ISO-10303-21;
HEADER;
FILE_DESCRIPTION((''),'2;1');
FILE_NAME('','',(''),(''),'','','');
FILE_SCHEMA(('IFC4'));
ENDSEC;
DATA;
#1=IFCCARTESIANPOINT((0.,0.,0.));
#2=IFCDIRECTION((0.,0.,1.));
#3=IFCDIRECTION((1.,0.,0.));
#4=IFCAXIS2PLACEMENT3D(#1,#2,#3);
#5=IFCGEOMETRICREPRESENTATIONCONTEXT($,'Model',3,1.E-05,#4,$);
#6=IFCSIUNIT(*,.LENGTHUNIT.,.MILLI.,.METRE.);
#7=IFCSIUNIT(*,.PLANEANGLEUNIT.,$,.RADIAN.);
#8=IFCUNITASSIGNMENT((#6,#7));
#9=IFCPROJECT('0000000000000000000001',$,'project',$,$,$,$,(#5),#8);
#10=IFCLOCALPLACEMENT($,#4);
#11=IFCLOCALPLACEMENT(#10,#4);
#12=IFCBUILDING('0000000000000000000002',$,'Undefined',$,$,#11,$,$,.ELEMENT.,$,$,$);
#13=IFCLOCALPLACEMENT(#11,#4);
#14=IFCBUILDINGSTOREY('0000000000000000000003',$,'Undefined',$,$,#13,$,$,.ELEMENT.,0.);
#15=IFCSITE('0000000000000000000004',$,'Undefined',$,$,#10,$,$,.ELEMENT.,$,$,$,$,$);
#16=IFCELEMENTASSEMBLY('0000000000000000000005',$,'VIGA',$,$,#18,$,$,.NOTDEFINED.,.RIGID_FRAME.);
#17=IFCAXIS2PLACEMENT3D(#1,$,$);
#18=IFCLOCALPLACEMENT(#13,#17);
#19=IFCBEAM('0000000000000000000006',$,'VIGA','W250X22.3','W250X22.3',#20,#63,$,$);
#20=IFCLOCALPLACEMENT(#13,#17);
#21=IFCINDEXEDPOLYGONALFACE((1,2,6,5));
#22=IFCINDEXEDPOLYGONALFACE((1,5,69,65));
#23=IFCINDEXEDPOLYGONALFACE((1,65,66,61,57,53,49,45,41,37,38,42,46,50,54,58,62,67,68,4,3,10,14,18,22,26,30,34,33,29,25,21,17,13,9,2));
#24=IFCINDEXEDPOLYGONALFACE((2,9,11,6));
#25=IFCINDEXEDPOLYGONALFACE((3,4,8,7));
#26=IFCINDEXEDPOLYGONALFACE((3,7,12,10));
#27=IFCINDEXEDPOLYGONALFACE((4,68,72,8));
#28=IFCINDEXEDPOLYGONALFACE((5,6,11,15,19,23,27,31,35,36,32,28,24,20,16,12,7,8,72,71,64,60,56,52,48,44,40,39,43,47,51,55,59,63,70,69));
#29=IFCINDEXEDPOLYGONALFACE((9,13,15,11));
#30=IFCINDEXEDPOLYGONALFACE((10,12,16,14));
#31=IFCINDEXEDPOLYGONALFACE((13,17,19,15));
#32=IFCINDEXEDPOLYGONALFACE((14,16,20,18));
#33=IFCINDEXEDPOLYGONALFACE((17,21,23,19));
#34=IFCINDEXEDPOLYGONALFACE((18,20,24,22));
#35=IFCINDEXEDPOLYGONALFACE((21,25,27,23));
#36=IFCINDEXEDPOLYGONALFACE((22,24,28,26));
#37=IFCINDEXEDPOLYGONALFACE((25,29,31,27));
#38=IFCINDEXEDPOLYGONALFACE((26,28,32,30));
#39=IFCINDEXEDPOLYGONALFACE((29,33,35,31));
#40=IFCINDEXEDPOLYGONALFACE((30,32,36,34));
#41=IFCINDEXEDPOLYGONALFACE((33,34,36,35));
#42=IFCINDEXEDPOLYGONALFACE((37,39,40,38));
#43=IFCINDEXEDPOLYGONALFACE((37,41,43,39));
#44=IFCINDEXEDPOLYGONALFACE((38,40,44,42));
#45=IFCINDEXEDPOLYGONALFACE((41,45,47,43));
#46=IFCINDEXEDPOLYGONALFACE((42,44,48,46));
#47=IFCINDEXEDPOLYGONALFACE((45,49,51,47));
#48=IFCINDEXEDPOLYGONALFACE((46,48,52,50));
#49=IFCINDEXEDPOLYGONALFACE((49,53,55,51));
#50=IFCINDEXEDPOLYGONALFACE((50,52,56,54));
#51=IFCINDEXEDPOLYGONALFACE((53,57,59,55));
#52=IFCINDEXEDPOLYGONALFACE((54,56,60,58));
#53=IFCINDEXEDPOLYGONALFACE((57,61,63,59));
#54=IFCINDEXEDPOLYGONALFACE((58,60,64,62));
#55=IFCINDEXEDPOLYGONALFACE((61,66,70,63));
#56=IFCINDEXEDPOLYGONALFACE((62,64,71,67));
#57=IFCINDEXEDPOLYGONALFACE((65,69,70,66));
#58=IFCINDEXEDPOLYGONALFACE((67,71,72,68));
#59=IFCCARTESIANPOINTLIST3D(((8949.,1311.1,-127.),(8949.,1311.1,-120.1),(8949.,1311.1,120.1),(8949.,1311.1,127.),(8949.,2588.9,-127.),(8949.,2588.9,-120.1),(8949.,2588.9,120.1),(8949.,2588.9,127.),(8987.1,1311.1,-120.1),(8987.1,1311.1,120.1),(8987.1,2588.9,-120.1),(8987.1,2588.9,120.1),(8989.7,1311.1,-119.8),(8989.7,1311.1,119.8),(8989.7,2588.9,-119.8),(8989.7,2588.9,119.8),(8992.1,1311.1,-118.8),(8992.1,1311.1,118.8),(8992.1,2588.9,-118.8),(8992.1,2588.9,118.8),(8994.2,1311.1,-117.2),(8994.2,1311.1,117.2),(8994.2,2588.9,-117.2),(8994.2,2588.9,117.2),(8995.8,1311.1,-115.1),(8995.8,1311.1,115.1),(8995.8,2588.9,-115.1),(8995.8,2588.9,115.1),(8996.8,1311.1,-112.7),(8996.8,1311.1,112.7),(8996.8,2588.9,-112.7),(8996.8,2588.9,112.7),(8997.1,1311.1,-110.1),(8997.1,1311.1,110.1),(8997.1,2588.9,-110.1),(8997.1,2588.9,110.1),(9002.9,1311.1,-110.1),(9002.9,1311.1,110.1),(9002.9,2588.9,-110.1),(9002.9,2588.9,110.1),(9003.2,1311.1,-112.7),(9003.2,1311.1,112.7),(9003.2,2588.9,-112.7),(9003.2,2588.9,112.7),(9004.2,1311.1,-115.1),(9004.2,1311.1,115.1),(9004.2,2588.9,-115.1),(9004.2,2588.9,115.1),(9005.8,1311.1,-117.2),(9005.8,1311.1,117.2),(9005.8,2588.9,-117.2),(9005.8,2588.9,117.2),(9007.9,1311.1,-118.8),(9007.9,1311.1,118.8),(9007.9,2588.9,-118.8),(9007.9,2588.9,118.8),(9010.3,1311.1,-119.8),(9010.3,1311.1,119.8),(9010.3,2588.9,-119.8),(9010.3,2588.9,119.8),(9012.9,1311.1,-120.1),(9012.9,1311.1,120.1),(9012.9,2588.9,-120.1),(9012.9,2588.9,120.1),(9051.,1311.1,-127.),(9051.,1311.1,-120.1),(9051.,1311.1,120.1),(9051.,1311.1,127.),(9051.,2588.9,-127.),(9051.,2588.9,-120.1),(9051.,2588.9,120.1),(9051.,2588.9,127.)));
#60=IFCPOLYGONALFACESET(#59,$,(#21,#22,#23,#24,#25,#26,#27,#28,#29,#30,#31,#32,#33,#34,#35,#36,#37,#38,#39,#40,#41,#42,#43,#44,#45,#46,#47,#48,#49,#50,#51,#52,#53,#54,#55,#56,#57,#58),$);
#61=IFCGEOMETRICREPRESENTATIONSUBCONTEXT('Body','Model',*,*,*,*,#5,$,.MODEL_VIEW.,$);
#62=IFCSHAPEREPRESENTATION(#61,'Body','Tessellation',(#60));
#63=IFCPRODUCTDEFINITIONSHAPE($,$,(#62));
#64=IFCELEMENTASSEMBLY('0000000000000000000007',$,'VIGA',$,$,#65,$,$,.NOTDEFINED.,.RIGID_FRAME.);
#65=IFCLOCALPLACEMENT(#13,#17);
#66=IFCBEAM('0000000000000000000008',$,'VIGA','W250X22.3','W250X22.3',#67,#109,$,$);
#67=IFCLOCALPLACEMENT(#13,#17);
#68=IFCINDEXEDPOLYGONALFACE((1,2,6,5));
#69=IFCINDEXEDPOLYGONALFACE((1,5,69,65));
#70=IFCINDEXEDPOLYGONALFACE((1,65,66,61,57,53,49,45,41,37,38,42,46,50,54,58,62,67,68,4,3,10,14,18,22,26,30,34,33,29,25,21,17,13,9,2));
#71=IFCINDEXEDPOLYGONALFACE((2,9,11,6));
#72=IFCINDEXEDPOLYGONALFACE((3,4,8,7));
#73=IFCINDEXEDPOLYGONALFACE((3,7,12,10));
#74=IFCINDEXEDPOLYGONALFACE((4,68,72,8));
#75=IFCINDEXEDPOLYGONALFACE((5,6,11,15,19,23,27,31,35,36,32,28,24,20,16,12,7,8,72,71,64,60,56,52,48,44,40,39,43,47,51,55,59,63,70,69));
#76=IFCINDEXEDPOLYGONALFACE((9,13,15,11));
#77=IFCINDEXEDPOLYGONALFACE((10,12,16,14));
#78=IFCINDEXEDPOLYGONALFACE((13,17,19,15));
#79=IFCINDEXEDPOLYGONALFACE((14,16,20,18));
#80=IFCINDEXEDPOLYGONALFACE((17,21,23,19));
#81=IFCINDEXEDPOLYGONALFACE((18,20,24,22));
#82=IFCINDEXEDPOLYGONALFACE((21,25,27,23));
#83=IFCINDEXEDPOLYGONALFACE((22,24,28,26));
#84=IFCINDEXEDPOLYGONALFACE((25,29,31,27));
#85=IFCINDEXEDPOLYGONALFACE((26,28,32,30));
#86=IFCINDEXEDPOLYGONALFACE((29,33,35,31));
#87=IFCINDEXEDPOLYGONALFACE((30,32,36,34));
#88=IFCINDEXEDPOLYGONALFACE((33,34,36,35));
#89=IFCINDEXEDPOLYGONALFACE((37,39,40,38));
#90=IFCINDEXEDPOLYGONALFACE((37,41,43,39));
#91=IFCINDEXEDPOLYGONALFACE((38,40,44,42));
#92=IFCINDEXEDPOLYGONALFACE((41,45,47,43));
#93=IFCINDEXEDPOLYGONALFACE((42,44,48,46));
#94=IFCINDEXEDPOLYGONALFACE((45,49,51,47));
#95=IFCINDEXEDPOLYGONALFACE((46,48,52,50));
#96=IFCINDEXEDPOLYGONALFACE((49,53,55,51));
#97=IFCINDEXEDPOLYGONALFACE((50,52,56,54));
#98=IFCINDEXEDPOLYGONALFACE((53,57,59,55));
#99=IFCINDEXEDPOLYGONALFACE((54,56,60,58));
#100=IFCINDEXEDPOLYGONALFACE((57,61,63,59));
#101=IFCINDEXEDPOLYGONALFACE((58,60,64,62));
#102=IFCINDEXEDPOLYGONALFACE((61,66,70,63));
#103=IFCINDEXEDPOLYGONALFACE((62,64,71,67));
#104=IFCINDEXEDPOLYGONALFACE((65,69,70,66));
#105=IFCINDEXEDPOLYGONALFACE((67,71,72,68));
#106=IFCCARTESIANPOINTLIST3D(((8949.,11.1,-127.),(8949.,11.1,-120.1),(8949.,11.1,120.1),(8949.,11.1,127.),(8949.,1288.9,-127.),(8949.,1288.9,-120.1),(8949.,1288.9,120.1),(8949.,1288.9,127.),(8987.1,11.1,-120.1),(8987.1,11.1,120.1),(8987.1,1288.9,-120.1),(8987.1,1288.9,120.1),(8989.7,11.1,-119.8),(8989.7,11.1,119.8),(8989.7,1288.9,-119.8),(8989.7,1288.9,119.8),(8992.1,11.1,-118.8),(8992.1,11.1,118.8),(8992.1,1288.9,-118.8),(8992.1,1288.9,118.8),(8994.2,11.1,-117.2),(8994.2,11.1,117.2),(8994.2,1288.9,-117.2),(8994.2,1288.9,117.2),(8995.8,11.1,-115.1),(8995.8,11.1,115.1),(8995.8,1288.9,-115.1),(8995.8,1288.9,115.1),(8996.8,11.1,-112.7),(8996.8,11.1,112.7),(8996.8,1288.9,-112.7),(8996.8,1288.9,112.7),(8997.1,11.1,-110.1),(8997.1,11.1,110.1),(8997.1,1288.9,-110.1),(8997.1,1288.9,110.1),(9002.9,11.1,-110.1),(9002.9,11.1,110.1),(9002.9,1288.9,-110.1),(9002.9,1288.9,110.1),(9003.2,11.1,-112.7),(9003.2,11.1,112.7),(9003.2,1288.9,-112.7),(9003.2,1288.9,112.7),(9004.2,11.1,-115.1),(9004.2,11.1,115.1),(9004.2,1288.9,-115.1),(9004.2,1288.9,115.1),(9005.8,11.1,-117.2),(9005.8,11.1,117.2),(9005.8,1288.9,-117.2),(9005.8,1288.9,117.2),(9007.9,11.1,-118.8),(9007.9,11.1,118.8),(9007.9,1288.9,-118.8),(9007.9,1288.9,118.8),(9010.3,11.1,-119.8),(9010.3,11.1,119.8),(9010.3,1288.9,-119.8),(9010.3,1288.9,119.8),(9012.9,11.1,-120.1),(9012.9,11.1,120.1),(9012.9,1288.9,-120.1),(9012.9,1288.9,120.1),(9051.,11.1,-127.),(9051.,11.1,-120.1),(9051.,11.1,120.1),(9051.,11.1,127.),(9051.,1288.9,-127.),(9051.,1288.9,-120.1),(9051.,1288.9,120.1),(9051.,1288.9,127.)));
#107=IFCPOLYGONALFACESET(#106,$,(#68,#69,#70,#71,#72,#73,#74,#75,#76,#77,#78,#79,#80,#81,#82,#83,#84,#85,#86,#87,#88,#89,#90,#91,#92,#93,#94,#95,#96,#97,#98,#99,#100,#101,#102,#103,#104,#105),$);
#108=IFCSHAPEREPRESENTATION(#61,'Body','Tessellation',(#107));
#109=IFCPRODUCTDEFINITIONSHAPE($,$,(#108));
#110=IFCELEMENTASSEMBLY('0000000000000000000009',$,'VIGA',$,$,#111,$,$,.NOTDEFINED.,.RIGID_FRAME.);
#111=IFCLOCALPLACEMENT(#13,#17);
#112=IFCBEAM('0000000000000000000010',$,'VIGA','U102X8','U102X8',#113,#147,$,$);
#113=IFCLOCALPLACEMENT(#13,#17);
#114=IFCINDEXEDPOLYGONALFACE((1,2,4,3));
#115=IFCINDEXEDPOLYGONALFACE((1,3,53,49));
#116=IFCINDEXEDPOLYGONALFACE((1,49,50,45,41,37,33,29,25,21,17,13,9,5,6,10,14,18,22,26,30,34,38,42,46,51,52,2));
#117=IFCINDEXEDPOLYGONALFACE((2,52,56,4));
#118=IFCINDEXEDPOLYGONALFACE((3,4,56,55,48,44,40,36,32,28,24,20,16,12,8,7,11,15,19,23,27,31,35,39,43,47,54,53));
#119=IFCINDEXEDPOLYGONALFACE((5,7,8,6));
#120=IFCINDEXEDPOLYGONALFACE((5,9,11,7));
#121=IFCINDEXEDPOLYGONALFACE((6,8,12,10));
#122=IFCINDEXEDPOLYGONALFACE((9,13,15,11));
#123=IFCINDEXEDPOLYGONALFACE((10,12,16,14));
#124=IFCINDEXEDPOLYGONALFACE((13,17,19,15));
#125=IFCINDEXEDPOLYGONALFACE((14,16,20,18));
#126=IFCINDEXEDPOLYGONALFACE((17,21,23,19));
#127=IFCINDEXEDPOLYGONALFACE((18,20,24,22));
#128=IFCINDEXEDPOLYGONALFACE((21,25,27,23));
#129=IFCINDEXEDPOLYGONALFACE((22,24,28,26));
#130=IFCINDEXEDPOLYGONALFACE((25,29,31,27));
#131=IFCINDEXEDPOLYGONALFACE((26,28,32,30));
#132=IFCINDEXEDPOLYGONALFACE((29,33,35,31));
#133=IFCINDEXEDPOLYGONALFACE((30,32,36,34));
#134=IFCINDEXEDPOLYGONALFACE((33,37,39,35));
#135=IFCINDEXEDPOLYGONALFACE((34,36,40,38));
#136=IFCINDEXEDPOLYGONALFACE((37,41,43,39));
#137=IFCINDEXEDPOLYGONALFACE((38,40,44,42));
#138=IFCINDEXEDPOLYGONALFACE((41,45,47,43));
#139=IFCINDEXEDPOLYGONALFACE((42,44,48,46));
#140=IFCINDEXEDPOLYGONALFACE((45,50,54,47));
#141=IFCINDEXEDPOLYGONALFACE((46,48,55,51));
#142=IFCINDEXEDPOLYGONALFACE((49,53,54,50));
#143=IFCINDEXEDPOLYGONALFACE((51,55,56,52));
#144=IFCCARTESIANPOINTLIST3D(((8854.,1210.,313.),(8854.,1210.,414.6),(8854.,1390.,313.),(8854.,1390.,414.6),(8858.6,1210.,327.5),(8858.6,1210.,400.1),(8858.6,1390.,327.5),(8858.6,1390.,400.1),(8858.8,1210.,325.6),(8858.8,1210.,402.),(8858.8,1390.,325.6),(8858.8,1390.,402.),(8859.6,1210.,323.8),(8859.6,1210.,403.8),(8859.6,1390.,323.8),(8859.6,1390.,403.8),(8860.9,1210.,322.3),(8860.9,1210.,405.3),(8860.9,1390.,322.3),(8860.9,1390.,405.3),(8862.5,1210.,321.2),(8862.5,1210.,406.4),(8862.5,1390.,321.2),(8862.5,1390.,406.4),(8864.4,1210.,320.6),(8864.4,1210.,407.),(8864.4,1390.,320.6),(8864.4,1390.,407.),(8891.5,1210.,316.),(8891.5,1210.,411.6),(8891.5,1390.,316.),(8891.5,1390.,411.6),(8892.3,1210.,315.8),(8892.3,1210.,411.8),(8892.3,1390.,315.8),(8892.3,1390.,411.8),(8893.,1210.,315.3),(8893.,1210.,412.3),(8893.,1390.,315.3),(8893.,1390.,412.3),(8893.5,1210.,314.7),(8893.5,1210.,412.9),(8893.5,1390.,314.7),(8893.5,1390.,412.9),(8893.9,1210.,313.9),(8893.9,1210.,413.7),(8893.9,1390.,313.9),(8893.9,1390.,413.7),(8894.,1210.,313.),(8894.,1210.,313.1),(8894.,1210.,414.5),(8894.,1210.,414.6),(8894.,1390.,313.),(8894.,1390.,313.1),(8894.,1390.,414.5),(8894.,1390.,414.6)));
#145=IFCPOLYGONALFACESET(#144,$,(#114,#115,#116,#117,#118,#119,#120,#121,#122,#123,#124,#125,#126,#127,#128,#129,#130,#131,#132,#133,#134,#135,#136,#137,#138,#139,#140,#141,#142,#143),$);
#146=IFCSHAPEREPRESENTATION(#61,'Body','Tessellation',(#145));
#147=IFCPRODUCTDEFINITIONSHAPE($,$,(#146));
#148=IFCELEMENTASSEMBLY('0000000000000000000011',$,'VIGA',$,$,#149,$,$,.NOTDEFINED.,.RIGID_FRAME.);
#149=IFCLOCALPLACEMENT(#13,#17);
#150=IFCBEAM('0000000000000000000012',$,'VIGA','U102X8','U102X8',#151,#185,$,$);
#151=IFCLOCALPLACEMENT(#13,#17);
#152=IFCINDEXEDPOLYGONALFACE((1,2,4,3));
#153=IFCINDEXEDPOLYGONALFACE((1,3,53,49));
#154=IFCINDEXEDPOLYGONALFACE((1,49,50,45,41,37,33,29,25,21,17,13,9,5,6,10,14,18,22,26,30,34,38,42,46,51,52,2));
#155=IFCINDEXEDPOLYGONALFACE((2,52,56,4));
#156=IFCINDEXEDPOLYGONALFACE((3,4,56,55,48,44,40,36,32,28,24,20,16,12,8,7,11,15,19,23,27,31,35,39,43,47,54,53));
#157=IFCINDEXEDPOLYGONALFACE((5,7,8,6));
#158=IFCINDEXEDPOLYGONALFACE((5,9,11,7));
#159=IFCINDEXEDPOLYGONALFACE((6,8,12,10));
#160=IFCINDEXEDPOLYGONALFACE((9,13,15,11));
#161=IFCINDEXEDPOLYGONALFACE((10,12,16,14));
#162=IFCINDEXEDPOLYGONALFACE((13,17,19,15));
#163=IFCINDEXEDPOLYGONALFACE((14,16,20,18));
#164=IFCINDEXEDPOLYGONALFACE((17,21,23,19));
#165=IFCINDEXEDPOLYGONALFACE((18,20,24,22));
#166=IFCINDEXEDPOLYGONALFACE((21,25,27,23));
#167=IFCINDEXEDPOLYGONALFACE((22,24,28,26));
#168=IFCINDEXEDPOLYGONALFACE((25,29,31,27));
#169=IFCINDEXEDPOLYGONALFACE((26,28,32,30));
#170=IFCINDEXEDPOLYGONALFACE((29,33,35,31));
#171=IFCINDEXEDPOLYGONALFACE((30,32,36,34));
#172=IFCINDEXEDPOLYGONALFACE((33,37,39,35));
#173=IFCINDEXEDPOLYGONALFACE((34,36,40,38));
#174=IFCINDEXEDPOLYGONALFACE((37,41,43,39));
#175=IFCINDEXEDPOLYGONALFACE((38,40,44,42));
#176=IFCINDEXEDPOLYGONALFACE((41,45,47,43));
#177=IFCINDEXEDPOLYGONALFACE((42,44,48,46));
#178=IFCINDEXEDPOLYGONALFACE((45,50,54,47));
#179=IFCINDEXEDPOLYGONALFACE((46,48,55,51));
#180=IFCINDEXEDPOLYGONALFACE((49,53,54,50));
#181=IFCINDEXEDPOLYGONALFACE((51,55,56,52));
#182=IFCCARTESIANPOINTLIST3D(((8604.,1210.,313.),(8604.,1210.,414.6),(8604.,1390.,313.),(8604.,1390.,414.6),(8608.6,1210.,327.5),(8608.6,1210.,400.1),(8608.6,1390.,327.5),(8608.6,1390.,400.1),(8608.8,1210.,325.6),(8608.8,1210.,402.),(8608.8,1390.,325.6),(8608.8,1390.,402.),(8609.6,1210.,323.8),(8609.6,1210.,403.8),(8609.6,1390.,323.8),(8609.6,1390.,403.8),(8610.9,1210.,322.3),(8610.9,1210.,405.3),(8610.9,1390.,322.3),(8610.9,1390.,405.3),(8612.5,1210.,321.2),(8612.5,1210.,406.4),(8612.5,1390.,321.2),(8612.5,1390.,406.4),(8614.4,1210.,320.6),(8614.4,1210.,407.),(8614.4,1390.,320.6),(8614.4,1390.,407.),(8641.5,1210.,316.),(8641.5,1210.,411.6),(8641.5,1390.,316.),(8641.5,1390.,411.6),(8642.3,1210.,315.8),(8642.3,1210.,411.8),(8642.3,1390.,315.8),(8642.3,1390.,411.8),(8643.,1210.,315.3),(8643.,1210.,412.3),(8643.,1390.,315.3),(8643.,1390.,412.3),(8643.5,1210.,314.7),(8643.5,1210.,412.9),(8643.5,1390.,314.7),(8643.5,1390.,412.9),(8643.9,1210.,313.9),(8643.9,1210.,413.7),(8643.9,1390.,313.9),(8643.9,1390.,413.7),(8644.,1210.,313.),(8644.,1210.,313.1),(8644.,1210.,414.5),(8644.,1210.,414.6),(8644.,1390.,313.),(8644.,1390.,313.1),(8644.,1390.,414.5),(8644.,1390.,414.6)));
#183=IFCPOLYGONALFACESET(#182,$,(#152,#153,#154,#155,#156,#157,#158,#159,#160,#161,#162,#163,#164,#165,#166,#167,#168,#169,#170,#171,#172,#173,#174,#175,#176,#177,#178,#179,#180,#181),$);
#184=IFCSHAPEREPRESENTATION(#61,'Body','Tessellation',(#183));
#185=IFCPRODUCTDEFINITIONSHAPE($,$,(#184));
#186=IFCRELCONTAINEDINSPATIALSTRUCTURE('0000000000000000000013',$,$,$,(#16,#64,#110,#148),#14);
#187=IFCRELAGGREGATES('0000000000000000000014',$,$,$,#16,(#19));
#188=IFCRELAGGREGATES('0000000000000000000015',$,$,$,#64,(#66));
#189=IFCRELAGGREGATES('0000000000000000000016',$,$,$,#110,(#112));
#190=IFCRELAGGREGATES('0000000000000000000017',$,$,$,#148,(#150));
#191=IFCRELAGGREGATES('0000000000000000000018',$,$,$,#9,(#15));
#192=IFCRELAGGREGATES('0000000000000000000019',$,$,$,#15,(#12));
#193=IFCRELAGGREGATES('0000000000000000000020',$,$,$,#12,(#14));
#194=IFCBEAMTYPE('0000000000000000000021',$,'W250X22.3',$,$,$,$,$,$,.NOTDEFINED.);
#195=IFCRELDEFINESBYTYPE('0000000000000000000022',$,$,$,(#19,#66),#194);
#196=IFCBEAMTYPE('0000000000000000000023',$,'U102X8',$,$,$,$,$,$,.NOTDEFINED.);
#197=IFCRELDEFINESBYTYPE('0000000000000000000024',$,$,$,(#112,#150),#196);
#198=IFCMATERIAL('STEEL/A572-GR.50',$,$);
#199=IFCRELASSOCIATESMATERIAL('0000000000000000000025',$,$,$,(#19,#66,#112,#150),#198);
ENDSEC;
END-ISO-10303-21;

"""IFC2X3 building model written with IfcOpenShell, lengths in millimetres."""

from ifc_helpers import new_model, si_unit, frame, origin_with_axes, origin_2d_with_axis, place, context, subcontext, project, spatial, i_section, u_section, extrude, material, type_object, element, aggregate, save


model = new_model("IFC2X3")

# Units and contexts
model_context = context("Model", 3, precision=1e-05, world=origin_with_axes())
body_context = subcontext(model_context, "Body", "Model", "MODEL_VIEW")
ifc_project = project(units=[si_unit("LENGTHUNIT", "METRE", prefix="MILLI"), si_unit("PLANEANGLEUNIT", "RADIAN")], contexts=[model_context])

# Site, building, storey
site_placement = place(None, origin_with_axes())
site = spatial("IfcSite", under=ifc_project, at=site_placement, Name="Undefined", CompositionType="ELEMENT")
building_placement = place(site_placement, origin_with_axes())
building = spatial("IfcBuilding", under=site, at=building_placement, Name="Undefined", CompositionType="ELEMENT")
storey_placement = place(building_placement, origin_with_axes())
storey = spatial("IfcBuildingStorey", under=building, at=storey_placement, Name="Undefined", CompositionType="ELEMENT", Elevation=0.0)

# Element assemblies, beams
assembly_1_placement = place(storey_placement, origin_with_axes())
assembly_1 = element("IfcElementAssembly", 1, at=assembly_1_placement, inside=storey, Name="VIGA", AssemblyPlace="NOTDEFINED", PredefinedType="RIGID_FRAME")
ifc_material_1 = material(Name="STEEL/A572-GR.50")
beam_type_1 = type_object("IfcBeamType", Name="W250X22.3", PredefinedType="NOTDEFINED")
beam_1_placement = place(assembly_1_placement, frame((9000.0, 1311.1, 0.0), z_axis=(0.0, 0.0, 1.0), x_axis=(0.0, 1.0, 0.0)))
beam_1 = element("IfcBeam", 2, at=beam_1_placement, type_object=beam_type_1, material=ifc_material_1, Name="VIGA", Description="W250X22.3", ObjectType="W250X22.3", context=body_context, shape_type="SweptSolid", body=[
    extrude(i_section(OverallWidth=102.0, OverallDepth=254.0, WebThickness=5.8, FlangeThickness=6.9, FilletRadius=10.0, at=origin_2d_with_axis()), frame((1277.8, 0.0, 0.0), z_axis=(-1.0, 0.0, 0.0), x_axis=(0.0, -1.0, 0.0)), (0.0, 0.0, 1.0), 1277.8),
])
aggregate(assembly_1, [beam_1])
assembly_2_placement = place(storey_placement, origin_with_axes())
assembly_2 = element("IfcElementAssembly", 3, at=assembly_2_placement, inside=storey, Name="VIGA", AssemblyPlace="NOTDEFINED", PredefinedType="RIGID_FRAME")
beam_2_placement = place(assembly_2_placement, frame((9000.0, 11.1, 0.0), z_axis=(0.0, 0.0, 1.0), x_axis=(0.0, 1.0, 0.0)))
beam_2 = element("IfcBeam", 4, at=beam_2_placement, type_object=beam_type_1, material=ifc_material_1, Name="VIGA", Description="W250X22.3", ObjectType="W250X22.3", context=body_context, shape_type="SweptSolid", body=[
    extrude(i_section(OverallWidth=102.0, OverallDepth=254.0, WebThickness=5.8, FlangeThickness=6.9, FilletRadius=10.0, at=origin_2d_with_axis()), frame((1277.8, 0.0, 0.0), z_axis=(-1.0, 0.0, 0.0), x_axis=(0.0, -1.0, 0.0)), (0.0, 0.0, 1.0), 1277.8),
])
aggregate(assembly_2, [beam_2])
assembly_3_placement = place(storey_placement, origin_with_axes())
assembly_3 = element("IfcElementAssembly", 5, at=assembly_3_placement, inside=storey, Name="VIGA", AssemblyPlace="NOTDEFINED", PredefinedType="RIGID_FRAME")
beam_type_2 = type_object("IfcBeamType", Name="U102X8", PredefinedType="NOTDEFINED")
beam_3_placement = place(assembly_3_placement, frame((8874.0, 1210.0, 363.8), z_axis=(0.0, 0.0, 1.0), x_axis=(0.0, 1.0, 0.0)))
beam_3 = element("IfcBeam", 6, at=beam_3_placement, type_object=beam_type_2, material=ifc_material_1, Name="VIGA", Description="U102X8", ObjectType="U102X8", context=body_context, shape_type="SweptSolid", body=[
    extrude(u_section(Depth=101.6, FlangeWidth=40.0, WebThickness=4.6, FlangeThickness=6.0, FilletRadius=7.0, EdgeRadius=3.0, FlangeSlope=0.16839, at=origin_2d_with_axis()), frame((180.0, 0.0, 0.0), z_axis=(-1.0, 0.0, 0.0), x_axis=(0.0, -1.0, 0.0)), (0.0, 0.0, 1.0), 180.0),
])
aggregate(assembly_3, [beam_3])
assembly_4_placement = place(storey_placement, origin_with_axes())
assembly_4 = element("IfcElementAssembly", 7, at=assembly_4_placement, inside=storey, Name="VIGA", AssemblyPlace="NOTDEFINED", PredefinedType="RIGID_FRAME")
beam_4_placement = place(assembly_4_placement, frame((8624.0, 1210.0, 363.8), z_axis=(0.0, 0.0, 1.0), x_axis=(0.0, 1.0, 0.0)))
beam_4 = element("IfcBeam", 8, at=beam_4_placement, type_object=beam_type_2, material=ifc_material_1, Name="VIGA", Description="U102X8", ObjectType="U102X8", context=body_context, shape_type="SweptSolid", body=[
    extrude(u_section(Depth=101.6, FlangeWidth=40.0, WebThickness=4.6, FlangeThickness=6.0, FilletRadius=7.0, EdgeRadius=3.0, FlangeSlope=0.16839, at=origin_2d_with_axis()), frame((180.0, 0.0, 0.0), z_axis=(-1.0, 0.0, 0.0), x_axis=(0.0, -1.0, 0.0)), (0.0, 0.0, 1.0), 180.0),
])
aggregate(assembly_4, [beam_4])

save(model, "model.ifc")
